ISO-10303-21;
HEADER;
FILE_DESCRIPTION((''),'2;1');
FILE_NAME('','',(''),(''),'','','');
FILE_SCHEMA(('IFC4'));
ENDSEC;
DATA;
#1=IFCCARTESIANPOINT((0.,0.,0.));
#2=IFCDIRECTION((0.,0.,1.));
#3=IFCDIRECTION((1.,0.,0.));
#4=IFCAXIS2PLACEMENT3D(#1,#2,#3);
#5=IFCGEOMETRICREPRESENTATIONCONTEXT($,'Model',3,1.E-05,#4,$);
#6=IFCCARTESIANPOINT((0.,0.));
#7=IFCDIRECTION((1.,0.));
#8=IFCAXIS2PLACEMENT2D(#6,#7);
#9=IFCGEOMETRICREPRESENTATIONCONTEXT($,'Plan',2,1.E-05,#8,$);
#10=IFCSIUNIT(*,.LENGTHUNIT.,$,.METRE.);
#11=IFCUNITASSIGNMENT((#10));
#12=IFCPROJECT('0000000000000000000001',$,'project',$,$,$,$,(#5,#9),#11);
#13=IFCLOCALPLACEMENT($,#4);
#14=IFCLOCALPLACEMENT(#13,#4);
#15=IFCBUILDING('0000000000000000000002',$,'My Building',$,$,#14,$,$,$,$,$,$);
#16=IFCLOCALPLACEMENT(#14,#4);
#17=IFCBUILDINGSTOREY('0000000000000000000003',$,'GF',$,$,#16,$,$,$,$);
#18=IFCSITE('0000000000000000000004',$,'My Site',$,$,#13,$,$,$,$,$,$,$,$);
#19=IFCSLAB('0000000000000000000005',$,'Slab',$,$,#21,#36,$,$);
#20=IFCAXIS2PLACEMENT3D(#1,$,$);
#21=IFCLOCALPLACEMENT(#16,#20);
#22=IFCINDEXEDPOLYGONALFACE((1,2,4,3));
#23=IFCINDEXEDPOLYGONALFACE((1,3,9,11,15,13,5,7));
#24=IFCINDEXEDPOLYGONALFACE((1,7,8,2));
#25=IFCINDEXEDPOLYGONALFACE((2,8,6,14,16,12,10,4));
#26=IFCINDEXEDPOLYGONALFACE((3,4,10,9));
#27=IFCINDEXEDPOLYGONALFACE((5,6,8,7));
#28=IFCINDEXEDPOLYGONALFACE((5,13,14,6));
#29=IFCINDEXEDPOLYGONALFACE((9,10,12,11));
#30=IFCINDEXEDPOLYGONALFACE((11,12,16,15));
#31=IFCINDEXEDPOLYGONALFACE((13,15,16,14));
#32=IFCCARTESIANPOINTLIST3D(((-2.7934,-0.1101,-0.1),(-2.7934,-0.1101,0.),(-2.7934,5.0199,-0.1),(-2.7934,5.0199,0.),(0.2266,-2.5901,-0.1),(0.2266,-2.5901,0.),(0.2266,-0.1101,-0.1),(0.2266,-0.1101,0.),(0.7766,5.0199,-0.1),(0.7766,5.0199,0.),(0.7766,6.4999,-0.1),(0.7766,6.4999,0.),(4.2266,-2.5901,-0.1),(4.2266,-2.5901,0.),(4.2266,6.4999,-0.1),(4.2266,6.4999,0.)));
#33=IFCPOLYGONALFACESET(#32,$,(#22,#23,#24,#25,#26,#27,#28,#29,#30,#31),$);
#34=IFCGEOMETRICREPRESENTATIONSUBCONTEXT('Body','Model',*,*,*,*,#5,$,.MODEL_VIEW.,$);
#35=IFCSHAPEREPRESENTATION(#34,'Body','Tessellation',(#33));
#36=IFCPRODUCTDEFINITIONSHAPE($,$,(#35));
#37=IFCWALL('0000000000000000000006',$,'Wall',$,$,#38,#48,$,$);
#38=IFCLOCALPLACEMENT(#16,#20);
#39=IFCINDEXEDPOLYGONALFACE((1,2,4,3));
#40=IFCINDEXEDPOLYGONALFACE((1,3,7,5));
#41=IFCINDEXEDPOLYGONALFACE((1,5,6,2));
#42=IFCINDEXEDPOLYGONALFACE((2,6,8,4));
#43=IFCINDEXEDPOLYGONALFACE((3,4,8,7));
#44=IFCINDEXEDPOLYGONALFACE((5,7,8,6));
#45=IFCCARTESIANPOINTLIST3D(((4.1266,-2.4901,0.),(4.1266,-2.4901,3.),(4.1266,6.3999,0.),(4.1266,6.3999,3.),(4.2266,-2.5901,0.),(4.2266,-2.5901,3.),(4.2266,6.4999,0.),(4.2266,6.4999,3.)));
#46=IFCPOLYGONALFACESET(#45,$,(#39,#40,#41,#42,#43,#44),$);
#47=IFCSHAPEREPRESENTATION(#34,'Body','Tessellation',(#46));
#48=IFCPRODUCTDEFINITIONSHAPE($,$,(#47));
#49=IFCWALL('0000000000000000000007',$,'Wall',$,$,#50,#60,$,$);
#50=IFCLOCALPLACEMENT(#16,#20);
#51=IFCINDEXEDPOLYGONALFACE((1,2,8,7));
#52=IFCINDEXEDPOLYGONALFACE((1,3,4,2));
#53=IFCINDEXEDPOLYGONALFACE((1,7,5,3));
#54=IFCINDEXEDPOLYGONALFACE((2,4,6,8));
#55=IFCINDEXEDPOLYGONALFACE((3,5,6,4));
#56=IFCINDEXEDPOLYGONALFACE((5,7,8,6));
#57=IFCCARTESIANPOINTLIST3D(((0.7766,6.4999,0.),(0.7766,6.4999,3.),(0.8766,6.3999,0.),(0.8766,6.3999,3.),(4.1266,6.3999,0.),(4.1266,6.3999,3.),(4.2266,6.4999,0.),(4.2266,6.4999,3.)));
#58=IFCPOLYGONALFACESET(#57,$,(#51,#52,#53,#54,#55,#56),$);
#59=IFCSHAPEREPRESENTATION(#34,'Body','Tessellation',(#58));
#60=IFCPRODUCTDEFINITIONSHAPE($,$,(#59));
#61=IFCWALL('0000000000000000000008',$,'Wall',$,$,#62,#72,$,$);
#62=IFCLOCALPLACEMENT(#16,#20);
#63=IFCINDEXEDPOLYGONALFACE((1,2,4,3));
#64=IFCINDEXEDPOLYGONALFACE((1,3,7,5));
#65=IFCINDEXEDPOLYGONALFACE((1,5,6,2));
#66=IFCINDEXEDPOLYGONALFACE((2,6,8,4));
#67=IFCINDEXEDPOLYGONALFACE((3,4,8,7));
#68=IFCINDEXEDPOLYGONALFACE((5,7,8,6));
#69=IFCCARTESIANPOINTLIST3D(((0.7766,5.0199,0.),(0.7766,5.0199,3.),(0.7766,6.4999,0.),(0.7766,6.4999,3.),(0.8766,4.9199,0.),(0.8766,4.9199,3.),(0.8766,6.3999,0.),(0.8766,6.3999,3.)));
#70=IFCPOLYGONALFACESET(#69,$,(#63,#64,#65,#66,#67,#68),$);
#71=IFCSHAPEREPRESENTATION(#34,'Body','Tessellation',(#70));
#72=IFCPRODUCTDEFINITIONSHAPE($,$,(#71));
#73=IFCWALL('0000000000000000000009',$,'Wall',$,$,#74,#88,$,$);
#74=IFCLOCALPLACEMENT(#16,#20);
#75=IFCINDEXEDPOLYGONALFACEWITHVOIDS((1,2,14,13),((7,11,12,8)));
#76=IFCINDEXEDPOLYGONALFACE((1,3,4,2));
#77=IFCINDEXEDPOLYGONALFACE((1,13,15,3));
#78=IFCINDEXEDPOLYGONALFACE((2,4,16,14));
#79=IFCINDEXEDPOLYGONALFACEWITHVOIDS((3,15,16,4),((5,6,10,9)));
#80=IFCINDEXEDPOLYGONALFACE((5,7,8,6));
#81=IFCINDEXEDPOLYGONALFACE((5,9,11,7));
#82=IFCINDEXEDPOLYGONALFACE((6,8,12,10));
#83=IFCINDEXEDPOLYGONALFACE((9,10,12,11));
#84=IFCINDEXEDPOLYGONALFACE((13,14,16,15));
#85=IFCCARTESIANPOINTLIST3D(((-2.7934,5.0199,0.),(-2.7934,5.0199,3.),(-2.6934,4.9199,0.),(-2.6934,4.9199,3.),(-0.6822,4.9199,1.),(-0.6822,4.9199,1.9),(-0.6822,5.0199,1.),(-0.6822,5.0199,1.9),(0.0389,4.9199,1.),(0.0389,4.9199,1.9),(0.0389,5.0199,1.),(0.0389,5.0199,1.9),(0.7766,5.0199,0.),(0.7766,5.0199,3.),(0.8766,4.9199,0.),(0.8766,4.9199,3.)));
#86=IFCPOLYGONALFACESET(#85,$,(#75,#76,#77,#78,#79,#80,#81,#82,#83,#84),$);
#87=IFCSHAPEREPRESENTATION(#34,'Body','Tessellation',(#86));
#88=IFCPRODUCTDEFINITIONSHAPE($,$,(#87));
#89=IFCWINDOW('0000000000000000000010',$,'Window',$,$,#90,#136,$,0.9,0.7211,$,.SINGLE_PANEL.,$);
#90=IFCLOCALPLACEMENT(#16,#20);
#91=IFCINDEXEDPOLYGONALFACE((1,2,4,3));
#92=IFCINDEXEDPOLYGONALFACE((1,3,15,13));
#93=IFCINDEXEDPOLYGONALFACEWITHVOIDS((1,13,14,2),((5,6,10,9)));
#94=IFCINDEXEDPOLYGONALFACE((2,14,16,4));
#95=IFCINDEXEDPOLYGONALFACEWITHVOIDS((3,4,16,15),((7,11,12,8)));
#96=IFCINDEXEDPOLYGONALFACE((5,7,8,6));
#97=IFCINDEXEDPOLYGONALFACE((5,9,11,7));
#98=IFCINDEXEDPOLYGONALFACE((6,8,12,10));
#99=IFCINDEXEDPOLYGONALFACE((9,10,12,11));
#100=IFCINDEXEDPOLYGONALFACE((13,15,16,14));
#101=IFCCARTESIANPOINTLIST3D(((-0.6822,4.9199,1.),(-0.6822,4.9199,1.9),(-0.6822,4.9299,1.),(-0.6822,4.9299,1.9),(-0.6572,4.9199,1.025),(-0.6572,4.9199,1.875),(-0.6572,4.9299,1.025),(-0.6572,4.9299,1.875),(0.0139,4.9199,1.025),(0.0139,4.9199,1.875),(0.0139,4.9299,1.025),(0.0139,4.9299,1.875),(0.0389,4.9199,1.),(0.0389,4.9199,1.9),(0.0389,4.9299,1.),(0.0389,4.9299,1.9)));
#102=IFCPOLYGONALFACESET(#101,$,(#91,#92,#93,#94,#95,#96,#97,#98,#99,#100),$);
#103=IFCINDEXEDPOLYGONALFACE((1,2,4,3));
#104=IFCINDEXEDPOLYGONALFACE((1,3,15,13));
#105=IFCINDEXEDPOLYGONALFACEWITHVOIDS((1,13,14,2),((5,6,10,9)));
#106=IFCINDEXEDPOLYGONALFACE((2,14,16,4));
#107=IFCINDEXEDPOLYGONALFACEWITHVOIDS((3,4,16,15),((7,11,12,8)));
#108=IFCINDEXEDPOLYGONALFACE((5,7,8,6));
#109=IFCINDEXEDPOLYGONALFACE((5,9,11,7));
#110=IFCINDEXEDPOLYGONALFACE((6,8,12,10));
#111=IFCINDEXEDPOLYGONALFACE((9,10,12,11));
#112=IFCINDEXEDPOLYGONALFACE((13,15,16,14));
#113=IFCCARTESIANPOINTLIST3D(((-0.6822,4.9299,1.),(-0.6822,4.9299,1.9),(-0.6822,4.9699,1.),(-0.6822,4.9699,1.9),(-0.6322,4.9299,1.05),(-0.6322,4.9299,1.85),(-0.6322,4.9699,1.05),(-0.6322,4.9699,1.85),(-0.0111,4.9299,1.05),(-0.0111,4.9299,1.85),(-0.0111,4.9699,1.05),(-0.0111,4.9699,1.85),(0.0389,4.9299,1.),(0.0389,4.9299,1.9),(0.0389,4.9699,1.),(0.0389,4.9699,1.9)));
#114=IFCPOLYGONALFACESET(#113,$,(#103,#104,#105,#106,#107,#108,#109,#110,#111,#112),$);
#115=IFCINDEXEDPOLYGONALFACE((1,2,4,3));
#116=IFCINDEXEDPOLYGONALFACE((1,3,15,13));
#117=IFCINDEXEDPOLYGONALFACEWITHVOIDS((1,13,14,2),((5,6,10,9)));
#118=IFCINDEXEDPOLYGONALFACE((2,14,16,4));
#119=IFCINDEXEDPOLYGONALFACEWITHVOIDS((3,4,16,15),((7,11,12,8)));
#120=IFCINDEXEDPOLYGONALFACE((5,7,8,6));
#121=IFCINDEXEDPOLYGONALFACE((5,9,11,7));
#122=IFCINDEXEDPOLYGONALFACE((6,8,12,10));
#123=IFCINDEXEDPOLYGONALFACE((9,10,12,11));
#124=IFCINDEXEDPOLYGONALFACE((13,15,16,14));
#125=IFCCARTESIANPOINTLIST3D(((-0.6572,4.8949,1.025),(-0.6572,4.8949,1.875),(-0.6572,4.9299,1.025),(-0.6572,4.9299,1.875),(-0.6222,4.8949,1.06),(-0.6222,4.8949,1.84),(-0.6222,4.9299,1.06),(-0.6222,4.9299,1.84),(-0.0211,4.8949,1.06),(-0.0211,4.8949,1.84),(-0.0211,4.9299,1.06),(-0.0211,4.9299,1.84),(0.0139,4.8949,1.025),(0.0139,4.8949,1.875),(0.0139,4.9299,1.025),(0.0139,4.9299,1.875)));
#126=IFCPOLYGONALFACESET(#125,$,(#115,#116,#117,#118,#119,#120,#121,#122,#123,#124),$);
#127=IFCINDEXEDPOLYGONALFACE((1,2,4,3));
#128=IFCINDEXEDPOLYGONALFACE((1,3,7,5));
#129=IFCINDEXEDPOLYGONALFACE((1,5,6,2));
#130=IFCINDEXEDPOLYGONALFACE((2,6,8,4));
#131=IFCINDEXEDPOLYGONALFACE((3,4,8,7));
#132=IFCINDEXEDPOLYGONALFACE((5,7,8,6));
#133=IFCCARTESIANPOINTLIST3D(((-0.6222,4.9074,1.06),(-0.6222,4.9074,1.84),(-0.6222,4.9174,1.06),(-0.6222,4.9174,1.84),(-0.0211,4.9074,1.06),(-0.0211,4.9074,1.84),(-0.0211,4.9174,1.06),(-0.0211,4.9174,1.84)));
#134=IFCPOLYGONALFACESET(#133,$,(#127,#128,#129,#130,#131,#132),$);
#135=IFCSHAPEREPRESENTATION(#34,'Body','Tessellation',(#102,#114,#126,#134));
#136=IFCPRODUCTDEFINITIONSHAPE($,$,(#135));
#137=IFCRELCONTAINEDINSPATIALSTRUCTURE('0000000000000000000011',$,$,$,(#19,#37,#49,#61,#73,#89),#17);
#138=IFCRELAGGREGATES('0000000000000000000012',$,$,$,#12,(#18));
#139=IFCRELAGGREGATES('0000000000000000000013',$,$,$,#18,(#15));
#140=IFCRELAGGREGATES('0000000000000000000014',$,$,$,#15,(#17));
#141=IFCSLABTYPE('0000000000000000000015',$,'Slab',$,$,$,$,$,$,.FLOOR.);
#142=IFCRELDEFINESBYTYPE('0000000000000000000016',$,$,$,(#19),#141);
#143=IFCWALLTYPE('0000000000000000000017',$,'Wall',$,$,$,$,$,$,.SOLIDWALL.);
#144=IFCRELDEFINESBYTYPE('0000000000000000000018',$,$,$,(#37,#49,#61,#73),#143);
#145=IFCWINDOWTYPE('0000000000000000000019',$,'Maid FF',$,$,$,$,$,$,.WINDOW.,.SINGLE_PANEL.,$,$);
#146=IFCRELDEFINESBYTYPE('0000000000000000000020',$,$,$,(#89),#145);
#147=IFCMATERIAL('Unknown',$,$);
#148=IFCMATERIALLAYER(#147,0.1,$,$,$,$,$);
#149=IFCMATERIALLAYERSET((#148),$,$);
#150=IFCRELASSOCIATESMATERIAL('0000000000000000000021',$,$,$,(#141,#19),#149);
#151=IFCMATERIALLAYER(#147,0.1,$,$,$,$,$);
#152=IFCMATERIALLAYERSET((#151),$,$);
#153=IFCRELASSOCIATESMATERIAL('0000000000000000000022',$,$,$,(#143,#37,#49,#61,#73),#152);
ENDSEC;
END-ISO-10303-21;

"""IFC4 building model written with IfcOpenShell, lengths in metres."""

from ifc_helpers import new_model, entity, si_unit, frame, origin_with_axes, origin_2d_with_axis, place, context, subcontext, project, spatial, line, indexed_curve, outline, extrude, shape, source, transform, mapped, material, layer, layer_set, layer_usage, type_object, type_shapes, element, fill, save


model = new_model("IFC4")

# Units and contexts
model_context = context("Model", 3, precision=1e-05, world=origin_with_axes())
plan_context = context("Plan", 2, precision=1e-05, world=origin_2d_with_axis())
body_context_1 = subcontext(model_context, "Body", "Model", "MODEL_VIEW")
body_context_2 = subcontext(plan_context, "Body", "Plan", "PLAN_VIEW")
ifc_project = project(units=[si_unit("LENGTHUNIT", "METRE")], contexts=[model_context, plan_context])

# Site, building, storey
site_placement = place(None, origin_with_axes())
site = spatial("IfcSite", under=ifc_project, at=site_placement, Name="My Site")
building_placement = place(site_placement, origin_with_axes())
building = spatial("IfcBuilding", under=site, at=building_placement, Name="My Building")
storey_placement = place(building_placement, origin_with_axes())
storey = spatial("IfcBuildingStorey", under=building, at=storey_placement, Name="GF")

# Slab
ifc_material = material(Name="Unknown")
ifc_layer_1 = layer(ifc_material, 0.1)
ifc_layer_set_1 = layer_set([ifc_layer_1])
ifc_layer_usage_1 = layer_usage(ifc_layer_set_1, "AXIS3", "POSITIVE", -0.1)
slab_type = type_object("IfcSlabType", Name="Slab", PredefinedType="FLOOR", material=ifc_layer_set_1)
slab_placement = place(storey_placement, frame((4.2266, -2.5901, 0.0), z_axis=(0.0, 0.0, 1.0), x_axis=(1.0, 0.0, 0.0)))
element("IfcSlab", 1, at=slab_placement, inside=storey, type_object=slab_type, material=ifc_layer_usage_1, Name="Slab", context=body_context_1, shape_type="SweptSolid", body=[
    extrude(outline(indexed_curve([(0.0, 0.0), (0.0, 9.09), (-3.45, 9.09), (-3.45, 7.61), (-7.02, 7.61), (-7.02, 2.48), (-4.0, 2.48), (-4.0, 0.0), (0.0, 0.0)])), frame((0.0, 0.0, -0.1), z_axis=(0.0, 0.0, 1.0), x_axis=(1.0, 0.0, 0.0)), (0.0, 0.0, 1.0), 0.1),
])

# Shared definitions
ifc_layer_2 = layer(ifc_material, 0.1)
ifc_layer_set_2 = layer_set([ifc_layer_2])
wall_type = type_object("IfcWallType", Name="Wall", PredefinedType="SOLIDWALL", material=ifc_layer_set_2)

# Walls
ifc_layer_usage_2 = layer_usage(ifc_layer_set_2, "AXIS2", "POSITIVE", 0.0)
wall_1_placement = place(storey_placement, frame((4.2266, -2.5901, 0.0), z_axis=(0.0, 0.0, 1.0), x_axis=(0.0, 1.0, 0.0)))
element("IfcWall", 2, at=wall_1_placement, inside=storey, type_object=wall_type, material=ifc_layer_usage_2, Name="Wall", context=body_context_1, shape_type="SweptSolid", body=[
    extrude(outline(indexed_curve([(0.0, 0.0), (0.1, 0.1), (8.99, 0.1), (9.09, 0.0)], segments=[line(1, 2, 3, 4, 1)])), origin_with_axes(), (0.0, 0.0, 1.0), 3.0),
])
ifc_layer_usage_3 = layer_usage(ifc_layer_set_2, "AXIS2", "POSITIVE", 0.0)
wall_2_placement = place(storey_placement, frame((4.2266, 6.4999, 0.0), z_axis=(0.0, 0.0, 1.0), x_axis=(-1.0, 0.0, 0.0)))
element("IfcWall", 3, at=wall_2_placement, inside=storey, type_object=wall_type, material=ifc_layer_usage_3, Name="Wall", context=body_context_1, shape_type="SweptSolid", body=[
    extrude(outline(indexed_curve([(0.0, 0.0), (0.1, 0.1), (3.35, 0.1), (3.45, 0.0)], segments=[line(1, 2, 3, 4, 1)])), origin_with_axes(), (0.0, 0.0, 1.0), 3.0),
])
ifc_layer_usage_4 = layer_usage(ifc_layer_set_2, "AXIS2", "POSITIVE", 0.0)
wall_3_placement = place(storey_placement, frame((0.7766, 6.4999, 0.0), z_axis=(0.0, 0.0, 1.0), x_axis=(0.0, -1.0, 0.0)))
element("IfcWall", 4, at=wall_3_placement, inside=storey, type_object=wall_type, material=ifc_layer_usage_4, Name="Wall", context=body_context_1, shape_type="SweptSolid", body=[
    extrude(outline(indexed_curve([(0.0, 0.0), (0.1, 0.1), (1.58, 0.1), (1.48, 0.0)], segments=[line(1, 2, 3, 4, 1)])), origin_with_axes(), (0.0, 0.0, 1.0), 3.0),
])

# Wall, opening, window
ifc_layer_usage_5 = layer_usage(ifc_layer_set_2, "AXIS2", "POSITIVE", 0.0)
wall_4_placement = place(storey_placement, frame((0.7766, 5.0199, 0.0), z_axis=(0.0, 0.0, 1.0), x_axis=(-1.0, 0.0, 0.0)))
wall_4 = element("IfcWall", 5, at=wall_4_placement, inside=storey, type_object=wall_type, material=ifc_layer_usage_5, Name="Wall", context=body_context_1, shape_type="SweptSolid", body=[
    extrude(outline(indexed_curve([(0.0, 0.0), (-0.1, 0.1), (3.47, 0.1), (3.57, 0.0)], segments=[line(1, 2, 3, 4, 1)])), origin_with_axes(), (0.0, 0.0, 1.0), 3.0),
])
shared_shape_1 = source(origin_with_axes(), body_context_1, "Body", "SweptSolid", [
    extrude(outline(indexed_curve([(0.0, 0.0), (0.7211, 0.0), (0.7211, 0.9), (0.0, 0.9)], segments=[line(1, 2, 3, 4, 1)])), frame((0.0, -0.6, 0.0), z_axis=(0.0, -1.0, 0.0), x_axis=(1.0, 0.0, 0.0)), (0.0, 0.0, -1.0), 1.2),
])
opening_1_placement = place(wall_4_placement, frame((0.7377, 0.0, 1.0), z_axis=(0.0, 0.0, 1.0), x_axis=(1.0, 0.0, 0.0)))
opening_1 = element("IfcOpeningElement", 6, at=opening_1_placement, cuts=wall_4, PredefinedType="OPENING", context=body_context_1, shape_type="MappedRepresentation", body=[
    mapped(shared_shape_1, transform((0.0, 0.0, 0.0), x_axis=(1.0, 0.0, 0.0), y_axis=(0.0, 1.0, 0.0), z_axis=(0.0, 0.0, 1.0), scale=1.0)),
])
window_type_1 = type_object("IfcWindowType", Name="Maid FF", PartitioningType="SINGLE_PANEL", PredefinedType="WINDOW")
shared_shape_2 = source(origin_with_axes(), body_context_1, "Body", "SweptSolid", [
    extrude(outline(indexed_curve([(0.0, 0.0), (0.7211, 0.0), (0.7211, 0.9), (0.0, 0.9)], segments=[line(1, 2, 3, 4, 1)]), holes=[indexed_curve([(0.025, 0.025), (0.6961, 0.025), (0.6961, 0.875), (0.025, 0.875)], segments=[line(1, 2, 3, 4, 1)])]), frame((0.0, 0.09, 0.0), z_axis=(0.0, -1.0, 0.0), x_axis=(1.0, 0.0, 0.0)), (0.0, 0.0, -1.0), 0.01),
    extrude(outline(indexed_curve([(0.0, 0.0), (0.7211, 0.0), (0.7211, 0.9), (0.0, 0.9)], segments=[line(1, 2, 3, 4, 1)]), holes=[indexed_curve([(0.05, 0.05), (0.6711, 0.05), (0.6711, 0.85), (0.05, 0.85)], segments=[line(1, 2, 3, 4, 1)])]), frame((0.0, 0.05, 0.0), z_axis=(0.0, -1.0, 0.0), x_axis=(1.0, 0.0, 0.0)), (0.0, 0.0, -1.0), 0.04),
    extrude(outline(indexed_curve([(0.0, 0.0), (0.6711, 0.0), (0.6711, 0.85), (0.0, 0.85)], segments=[line(1, 2, 3, 4, 1)]), holes=[indexed_curve([(0.035, 0.035), (0.6361, 0.035), (0.6361, 0.815), (0.035, 0.815)], segments=[line(1, 2, 3, 4, 1)])]), frame((0.025, 0.09, 0.025), z_axis=(0.0, -1.0, 0.0), x_axis=(1.0, 0.0, 0.0)), (0.0, 0.0, -1.0), 0.035),
    extrude(outline(indexed_curve([(0.035, 0.035), (0.6361, 0.035), (0.6361, 0.815), (0.035, 0.815)], segments=[line(1, 2, 3, 4, 1)])), frame((0.025, 0.1025, 0.025), z_axis=(0.0, -1.0, 0.0), x_axis=(1.0, 0.0, 0.0)), (0.0, 0.0, -1.0), 0.01),
])
shared_shape_3 = source(origin_with_axes(), body_context_2, "Body", "Curve2D", [
    entity("IfcIndexedPolyCurve", entity("IfcCartesianPointList2D", [[0.05, 0.05], [0.6711, 0.05]])),
    entity("IfcIndexedPolyCurve", entity("IfcCartesianPointList2D", [[0.0, 0.1], [0.025, 0.1], [0.025, 0.09], [0.05, 0.09], [0.05, 0.05], [0.0, 0.05]]), [entity("IfcLineIndex", [1, 2, 3, 4, 5, 6, 1])]),
    entity("IfcIndexedPolyCurve", entity("IfcCartesianPointList2D", [[0.7211, 0.1], [0.6961, 0.1], [0.6961, 0.09], [0.6711, 0.09], [0.6711, 0.05], [0.7211, 0.05]]), [entity("IfcLineIndex", [1, 2, 3, 4, 5, 6, 1])]),
    entity("IfcIndexedPolyCurve", entity("IfcCartesianPointList2D", [[0.025, 0.09], [0.06, 0.09], [0.06, 0.125], [0.025, 0.125]]), [entity("IfcLineIndex", [1, 2, 3, 4, 1])]),
    entity("IfcIndexedPolyCurve", entity("IfcCartesianPointList2D", [[0.6961, 0.09], [0.6611, 0.09], [0.6611, 0.125], [0.6961, 0.125]]), [entity("IfcLineIndex", [1, 2, 3, 4, 1])]),
    entity("IfcIndexedPolyCurve", entity("IfcCartesianPointList2D", [[0.06, 0.09], [0.6611, 0.09]])),
    entity("IfcIndexedPolyCurve", entity("IfcCartesianPointList2D", [[0.06, 0.125], [0.6611, 0.125]])),
    entity("IfcIndexedPolyCurve", entity("IfcCartesianPointList2D", [[0.06, 0.1075], [0.6611, 0.1075]])),
])
type_shapes(window_type_1, [shared_shape_2, shared_shape_3])
window_1_placement = place(opening_1_placement, frame((0.0, 0.0, 0.0), z_axis=(0.0, 0.0, 1.0), x_axis=(1.0, 0.0, 0.0)))
window_1 = element("IfcWindow", 7, at=window_1_placement, inside=storey, type_object=window_type_1, Name="Window", OverallHeight=0.9, OverallWidth=0.7211, PartitioningType="SINGLE_PANEL", shapes=[
    shape(body_context_1, "Body", "MappedRepresentation", [mapped(shared_shape_2, transform((0.0, 0.0, 0.0), x_axis=(1.0, 0.0, 0.0), y_axis=(0.0, 1.0, 0.0), z_axis=(0.0, 0.0, 1.0), scale=1.0))]),
    shape(body_context_2, "Body", "MappedRepresentation", [mapped(shared_shape_3, transform((0.0, 0.0, 0.0), x_axis=(1.0, 0.0, 0.0), y_axis=(0.0, 1.0, 0.0), z_axis=(0.0, 0.0, 1.0), scale=1.0))]),
])
fill(opening_1, window_1)

save(model, "model.ifc")
